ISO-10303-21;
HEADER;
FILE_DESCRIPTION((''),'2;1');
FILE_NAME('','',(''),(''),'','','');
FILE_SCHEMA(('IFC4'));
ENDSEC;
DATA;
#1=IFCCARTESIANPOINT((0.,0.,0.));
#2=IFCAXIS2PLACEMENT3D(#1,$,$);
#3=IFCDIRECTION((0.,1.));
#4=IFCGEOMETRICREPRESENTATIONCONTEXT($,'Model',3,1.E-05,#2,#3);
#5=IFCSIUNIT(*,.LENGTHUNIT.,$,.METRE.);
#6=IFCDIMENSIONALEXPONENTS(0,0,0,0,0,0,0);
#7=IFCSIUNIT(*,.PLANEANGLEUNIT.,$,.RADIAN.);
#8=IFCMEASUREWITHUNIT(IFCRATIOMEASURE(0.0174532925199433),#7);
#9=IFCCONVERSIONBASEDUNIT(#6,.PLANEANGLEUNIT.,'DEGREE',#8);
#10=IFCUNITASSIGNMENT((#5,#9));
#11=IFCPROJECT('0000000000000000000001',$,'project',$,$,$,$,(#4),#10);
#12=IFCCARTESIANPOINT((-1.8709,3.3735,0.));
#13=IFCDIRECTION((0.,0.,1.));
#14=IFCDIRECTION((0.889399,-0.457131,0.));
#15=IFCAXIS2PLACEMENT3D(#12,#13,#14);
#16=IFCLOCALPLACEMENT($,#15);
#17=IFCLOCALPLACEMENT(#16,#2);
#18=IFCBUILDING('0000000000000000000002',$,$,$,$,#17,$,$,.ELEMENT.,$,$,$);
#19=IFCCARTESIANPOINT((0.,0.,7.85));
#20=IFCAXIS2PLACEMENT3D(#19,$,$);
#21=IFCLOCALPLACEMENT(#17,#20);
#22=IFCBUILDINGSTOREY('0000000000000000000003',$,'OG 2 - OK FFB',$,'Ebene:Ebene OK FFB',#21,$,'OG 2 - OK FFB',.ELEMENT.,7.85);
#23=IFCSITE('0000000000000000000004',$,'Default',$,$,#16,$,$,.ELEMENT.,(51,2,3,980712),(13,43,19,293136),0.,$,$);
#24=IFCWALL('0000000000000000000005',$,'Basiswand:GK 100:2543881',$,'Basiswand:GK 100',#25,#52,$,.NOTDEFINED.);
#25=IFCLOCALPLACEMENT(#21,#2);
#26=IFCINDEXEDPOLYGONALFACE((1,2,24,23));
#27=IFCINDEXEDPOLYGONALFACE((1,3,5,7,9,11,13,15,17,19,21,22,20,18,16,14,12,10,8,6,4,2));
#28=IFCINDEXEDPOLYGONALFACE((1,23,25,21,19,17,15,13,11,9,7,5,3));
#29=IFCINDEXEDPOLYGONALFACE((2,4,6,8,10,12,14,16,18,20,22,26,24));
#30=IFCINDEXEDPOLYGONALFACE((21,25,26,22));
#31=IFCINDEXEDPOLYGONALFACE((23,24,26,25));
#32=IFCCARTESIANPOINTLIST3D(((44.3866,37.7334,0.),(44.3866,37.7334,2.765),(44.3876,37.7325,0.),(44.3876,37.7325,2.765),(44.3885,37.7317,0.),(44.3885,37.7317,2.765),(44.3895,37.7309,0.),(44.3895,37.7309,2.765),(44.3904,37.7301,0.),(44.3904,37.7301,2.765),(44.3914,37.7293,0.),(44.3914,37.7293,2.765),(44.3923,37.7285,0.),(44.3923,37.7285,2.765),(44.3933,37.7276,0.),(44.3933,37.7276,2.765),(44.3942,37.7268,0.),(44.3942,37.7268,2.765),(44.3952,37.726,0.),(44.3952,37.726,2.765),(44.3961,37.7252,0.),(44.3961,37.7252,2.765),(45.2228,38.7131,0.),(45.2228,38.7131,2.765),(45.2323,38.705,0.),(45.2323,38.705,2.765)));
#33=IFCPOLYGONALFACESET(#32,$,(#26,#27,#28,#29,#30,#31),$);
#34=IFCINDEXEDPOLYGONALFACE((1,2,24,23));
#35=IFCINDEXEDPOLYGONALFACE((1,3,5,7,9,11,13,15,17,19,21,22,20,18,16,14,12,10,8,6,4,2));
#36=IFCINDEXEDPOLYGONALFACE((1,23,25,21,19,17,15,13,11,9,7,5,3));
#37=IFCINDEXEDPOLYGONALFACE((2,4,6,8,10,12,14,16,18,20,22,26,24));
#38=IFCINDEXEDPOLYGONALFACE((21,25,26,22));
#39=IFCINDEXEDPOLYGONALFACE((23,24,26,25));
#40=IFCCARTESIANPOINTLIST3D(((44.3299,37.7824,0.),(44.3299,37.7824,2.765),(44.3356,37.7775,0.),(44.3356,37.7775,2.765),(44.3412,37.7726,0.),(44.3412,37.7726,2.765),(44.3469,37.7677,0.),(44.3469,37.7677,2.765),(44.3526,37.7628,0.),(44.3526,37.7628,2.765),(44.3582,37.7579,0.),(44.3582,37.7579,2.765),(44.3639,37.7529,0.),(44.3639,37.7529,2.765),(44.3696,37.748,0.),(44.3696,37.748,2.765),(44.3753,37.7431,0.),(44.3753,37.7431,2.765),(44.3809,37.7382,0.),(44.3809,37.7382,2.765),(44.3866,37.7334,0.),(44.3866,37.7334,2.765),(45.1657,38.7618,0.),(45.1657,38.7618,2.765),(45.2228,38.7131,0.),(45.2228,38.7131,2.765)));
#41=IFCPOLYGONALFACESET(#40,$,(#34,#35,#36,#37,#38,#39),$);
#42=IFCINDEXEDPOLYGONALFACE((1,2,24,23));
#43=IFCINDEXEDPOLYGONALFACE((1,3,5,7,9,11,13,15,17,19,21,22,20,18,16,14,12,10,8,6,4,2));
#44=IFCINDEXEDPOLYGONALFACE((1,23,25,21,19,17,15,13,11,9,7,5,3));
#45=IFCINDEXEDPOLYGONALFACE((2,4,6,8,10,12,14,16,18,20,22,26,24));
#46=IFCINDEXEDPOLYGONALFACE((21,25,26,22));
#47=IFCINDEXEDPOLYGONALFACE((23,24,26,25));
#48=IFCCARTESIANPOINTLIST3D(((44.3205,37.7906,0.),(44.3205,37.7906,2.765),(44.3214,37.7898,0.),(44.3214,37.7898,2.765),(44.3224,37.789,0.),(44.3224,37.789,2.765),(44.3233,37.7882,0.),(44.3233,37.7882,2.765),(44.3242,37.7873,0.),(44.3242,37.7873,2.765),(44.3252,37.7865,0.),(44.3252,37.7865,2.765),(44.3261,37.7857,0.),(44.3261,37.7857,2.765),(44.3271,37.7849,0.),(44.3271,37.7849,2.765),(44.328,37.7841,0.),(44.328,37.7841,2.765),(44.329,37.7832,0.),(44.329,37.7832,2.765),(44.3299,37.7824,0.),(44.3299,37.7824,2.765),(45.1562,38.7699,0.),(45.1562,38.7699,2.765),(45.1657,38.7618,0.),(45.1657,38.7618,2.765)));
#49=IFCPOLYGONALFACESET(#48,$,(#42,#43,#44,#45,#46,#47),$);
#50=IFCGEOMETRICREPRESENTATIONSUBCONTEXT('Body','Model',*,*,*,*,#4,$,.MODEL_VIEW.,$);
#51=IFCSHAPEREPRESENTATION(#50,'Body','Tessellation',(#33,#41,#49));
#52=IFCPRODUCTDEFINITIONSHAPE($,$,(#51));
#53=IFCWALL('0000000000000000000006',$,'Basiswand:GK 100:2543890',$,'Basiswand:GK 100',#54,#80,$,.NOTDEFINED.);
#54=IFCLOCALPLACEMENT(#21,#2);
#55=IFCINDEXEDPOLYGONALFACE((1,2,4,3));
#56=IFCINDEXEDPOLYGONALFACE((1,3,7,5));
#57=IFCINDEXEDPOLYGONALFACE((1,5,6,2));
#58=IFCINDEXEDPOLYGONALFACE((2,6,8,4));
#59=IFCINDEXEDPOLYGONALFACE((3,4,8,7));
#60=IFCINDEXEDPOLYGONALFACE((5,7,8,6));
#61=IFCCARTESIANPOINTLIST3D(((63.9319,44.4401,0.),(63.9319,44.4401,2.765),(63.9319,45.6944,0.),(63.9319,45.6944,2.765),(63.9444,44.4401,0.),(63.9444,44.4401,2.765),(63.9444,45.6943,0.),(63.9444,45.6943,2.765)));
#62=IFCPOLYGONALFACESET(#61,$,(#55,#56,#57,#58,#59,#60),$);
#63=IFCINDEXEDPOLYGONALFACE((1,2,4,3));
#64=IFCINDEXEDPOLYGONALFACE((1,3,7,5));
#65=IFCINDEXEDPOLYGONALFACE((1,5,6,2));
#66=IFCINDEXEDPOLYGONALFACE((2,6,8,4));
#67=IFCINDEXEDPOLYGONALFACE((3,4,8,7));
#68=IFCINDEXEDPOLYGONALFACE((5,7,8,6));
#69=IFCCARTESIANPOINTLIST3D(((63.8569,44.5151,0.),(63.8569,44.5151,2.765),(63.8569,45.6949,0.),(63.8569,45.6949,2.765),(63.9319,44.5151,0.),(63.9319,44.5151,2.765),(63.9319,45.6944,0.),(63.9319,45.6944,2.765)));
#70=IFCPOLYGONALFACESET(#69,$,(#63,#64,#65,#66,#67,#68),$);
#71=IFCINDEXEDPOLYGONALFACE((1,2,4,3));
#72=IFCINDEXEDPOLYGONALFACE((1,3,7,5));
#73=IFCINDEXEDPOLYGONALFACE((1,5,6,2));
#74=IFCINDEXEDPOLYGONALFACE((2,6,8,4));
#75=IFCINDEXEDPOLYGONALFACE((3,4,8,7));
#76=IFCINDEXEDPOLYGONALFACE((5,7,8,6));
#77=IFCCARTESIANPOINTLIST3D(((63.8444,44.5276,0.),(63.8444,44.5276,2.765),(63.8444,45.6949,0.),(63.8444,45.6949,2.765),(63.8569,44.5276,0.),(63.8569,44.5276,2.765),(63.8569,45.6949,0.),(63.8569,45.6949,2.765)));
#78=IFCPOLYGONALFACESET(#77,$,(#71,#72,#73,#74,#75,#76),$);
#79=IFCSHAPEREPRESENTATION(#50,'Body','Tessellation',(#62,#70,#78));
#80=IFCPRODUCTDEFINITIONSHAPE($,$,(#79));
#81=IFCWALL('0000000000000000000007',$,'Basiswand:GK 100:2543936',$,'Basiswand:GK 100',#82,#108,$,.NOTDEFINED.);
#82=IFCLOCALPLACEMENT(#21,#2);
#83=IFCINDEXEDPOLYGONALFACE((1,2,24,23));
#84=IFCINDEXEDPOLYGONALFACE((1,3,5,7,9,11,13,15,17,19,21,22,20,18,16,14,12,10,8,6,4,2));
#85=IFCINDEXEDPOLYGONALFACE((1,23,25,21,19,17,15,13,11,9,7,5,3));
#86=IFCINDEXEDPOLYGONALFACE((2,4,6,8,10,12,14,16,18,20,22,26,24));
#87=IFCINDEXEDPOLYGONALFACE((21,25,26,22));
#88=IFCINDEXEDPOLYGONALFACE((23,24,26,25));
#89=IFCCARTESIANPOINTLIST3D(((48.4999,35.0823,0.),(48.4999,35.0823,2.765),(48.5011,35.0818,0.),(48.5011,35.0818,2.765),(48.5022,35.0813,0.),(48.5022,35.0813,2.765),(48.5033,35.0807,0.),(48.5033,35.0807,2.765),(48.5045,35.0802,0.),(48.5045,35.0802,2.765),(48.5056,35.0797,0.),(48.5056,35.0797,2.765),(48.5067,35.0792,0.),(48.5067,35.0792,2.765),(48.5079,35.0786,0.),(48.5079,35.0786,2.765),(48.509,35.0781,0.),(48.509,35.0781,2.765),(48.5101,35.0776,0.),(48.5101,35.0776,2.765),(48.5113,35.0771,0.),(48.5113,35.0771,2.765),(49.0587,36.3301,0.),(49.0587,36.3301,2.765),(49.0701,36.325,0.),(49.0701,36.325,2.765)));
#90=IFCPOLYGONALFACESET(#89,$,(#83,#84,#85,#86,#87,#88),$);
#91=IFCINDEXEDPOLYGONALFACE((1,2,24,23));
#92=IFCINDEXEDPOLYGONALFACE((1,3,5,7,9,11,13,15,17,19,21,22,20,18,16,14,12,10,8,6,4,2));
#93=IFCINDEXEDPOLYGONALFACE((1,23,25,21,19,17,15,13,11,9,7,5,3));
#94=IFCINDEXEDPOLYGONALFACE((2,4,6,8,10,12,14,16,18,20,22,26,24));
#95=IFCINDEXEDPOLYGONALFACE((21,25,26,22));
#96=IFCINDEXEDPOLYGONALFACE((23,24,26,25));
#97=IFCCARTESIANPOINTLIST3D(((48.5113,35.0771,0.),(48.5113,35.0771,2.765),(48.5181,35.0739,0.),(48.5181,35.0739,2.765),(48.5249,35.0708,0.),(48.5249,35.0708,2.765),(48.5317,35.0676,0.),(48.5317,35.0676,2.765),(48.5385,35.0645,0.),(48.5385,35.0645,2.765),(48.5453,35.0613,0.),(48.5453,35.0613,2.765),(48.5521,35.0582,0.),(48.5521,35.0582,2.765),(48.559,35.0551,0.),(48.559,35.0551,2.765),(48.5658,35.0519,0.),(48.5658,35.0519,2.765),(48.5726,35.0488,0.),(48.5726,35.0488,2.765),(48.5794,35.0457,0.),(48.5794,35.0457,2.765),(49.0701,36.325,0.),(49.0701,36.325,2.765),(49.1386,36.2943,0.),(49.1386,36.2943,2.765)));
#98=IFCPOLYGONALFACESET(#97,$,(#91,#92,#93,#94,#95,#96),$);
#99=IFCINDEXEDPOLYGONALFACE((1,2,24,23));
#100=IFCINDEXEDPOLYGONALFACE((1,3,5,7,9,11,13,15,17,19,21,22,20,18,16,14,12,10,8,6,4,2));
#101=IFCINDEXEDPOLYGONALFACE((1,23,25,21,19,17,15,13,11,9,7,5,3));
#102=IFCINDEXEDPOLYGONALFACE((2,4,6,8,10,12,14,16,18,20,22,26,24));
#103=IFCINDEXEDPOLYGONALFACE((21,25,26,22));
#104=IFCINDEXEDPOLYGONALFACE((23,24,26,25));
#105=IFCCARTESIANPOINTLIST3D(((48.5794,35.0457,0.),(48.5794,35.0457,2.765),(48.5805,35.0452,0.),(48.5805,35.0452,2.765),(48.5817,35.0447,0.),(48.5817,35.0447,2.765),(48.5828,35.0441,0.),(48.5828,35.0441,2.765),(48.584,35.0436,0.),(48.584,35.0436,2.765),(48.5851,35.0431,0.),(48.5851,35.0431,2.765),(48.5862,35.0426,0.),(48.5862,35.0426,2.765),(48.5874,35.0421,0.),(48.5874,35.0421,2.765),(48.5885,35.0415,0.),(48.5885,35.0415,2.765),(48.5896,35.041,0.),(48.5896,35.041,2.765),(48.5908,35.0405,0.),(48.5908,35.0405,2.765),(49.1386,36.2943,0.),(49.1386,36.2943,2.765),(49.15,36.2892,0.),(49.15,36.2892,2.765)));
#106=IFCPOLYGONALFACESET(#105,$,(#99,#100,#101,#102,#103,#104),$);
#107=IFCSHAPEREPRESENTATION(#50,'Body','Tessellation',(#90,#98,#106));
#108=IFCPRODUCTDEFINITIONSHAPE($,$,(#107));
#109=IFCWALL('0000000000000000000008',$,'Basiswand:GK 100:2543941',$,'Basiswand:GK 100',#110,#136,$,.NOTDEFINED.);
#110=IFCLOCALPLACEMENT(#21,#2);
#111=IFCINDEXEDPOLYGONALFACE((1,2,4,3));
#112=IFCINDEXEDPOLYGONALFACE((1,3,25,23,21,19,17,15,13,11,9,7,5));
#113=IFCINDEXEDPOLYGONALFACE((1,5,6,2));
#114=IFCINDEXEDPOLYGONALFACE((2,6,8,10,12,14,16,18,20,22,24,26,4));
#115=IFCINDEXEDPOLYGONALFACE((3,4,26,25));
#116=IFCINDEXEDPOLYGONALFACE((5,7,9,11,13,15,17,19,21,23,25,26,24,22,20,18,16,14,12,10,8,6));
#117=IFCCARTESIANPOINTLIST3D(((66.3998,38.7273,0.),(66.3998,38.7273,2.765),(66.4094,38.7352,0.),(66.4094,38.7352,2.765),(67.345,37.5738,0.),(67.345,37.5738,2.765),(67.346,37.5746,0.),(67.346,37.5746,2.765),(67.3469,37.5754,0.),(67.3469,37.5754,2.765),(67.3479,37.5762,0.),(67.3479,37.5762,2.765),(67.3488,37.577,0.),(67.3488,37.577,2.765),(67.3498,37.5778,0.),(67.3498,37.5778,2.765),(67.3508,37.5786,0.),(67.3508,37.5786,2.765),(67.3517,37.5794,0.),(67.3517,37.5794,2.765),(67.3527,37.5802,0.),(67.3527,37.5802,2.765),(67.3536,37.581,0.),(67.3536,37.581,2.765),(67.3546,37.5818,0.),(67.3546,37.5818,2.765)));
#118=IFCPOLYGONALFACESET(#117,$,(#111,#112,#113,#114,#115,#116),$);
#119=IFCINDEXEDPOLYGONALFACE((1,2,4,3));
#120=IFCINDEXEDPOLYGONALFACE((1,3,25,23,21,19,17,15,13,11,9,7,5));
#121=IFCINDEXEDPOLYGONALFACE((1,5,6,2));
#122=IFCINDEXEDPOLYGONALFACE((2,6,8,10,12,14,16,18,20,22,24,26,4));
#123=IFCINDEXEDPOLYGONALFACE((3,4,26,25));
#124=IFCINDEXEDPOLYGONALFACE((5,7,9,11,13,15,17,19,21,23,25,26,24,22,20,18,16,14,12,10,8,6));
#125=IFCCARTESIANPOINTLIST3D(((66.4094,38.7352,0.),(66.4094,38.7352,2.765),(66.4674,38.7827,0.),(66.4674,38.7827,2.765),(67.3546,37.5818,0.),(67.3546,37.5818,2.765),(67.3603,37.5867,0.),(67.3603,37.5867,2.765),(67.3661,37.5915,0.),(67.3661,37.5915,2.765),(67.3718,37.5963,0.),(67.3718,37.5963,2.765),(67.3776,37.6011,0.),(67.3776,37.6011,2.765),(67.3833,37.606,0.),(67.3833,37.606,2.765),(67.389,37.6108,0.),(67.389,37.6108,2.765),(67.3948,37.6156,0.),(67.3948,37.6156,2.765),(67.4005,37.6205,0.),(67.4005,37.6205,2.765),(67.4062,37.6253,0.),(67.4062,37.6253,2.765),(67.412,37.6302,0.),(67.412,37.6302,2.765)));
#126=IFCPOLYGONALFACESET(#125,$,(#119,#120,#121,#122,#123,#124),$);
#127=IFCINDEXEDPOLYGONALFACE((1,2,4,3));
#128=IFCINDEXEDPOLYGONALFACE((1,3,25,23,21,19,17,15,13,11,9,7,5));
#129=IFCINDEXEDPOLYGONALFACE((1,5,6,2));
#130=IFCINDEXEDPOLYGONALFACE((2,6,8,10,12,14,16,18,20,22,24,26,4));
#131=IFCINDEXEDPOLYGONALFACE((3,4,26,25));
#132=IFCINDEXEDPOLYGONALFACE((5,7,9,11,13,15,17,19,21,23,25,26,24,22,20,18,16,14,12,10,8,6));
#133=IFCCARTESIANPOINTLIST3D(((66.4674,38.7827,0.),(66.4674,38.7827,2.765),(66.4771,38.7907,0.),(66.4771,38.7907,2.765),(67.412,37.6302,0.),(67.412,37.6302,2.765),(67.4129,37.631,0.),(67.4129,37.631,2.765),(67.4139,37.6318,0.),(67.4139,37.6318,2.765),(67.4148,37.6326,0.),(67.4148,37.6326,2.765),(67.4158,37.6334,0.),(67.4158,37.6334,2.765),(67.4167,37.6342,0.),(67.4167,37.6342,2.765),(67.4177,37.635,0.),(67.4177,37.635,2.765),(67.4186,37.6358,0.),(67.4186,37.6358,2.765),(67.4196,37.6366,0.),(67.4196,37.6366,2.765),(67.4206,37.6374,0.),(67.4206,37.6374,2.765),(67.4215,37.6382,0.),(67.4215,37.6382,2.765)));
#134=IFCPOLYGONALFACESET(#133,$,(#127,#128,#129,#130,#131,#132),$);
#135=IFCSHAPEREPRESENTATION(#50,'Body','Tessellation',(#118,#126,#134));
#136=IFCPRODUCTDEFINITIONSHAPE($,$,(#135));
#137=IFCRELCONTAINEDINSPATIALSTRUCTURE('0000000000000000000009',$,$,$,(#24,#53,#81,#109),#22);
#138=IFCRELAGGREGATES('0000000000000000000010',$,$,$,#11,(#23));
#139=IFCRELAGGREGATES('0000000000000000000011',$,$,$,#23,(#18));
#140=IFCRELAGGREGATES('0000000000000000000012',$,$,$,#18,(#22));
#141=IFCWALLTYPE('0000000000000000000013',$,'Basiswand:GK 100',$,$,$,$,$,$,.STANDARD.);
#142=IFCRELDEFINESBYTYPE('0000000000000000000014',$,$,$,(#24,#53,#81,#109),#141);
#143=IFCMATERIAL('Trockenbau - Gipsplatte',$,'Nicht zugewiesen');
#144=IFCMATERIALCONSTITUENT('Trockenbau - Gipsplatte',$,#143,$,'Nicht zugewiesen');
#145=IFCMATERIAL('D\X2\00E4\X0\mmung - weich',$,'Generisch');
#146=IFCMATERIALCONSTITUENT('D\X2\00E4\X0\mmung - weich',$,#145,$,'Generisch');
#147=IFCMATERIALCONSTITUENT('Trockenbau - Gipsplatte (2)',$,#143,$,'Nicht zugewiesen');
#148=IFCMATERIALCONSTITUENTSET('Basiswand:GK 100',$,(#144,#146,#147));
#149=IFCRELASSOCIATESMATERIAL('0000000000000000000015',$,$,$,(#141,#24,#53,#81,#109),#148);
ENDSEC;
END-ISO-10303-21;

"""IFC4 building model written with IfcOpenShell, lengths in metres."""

from ifc_helpers import new_model, entity, si_unit, converted_unit, direction, frame, origin, place, context, subcontext, project, spatial, indexed_curve, outline, extrude, material, constituent, constituent_set, type_object, element, save


model = new_model("IFC4")

# Units and contexts
model_context = context("Model", 3, precision=1e-05, world=origin(), true_north=direction((0.0, 1.0)))
body_context = subcontext(model_context, "Body", "Model", "MODEL_VIEW")
ifc_project = project(units=[si_unit("LENGTHUNIT", "METRE"), converted_unit("PLANEANGLEUNIT", "DEGREE", entity("IfcRatioMeasure", 0.0174532925199433), si_unit("PLANEANGLEUNIT", "RADIAN"), dimensions=[0, 0, 0, 0, 0, 0, 0])], contexts=[model_context])

# Site, building, storey
site_placement = place(None, frame((-1.8709, 3.3735, 0.0), z_axis=(0.0, 0.0, 1.0), x_axis=(0.889399, -0.457131, 0.0)))
site = spatial("IfcSite", under=ifc_project, at=site_placement, Name="Default", CompositionType="ELEMENT", RefLatitude=(51, 2, 3, 980712), RefLongitude=(13, 43, 19, 293136), RefElevation=0.0)
building_placement = place(site_placement, origin())
building = spatial("IfcBuilding", under=site, at=building_placement, CompositionType="ELEMENT")
storey_placement = place(building_placement, frame((0.0, 0.0, 7.85)))
storey = spatial("IfcBuildingStorey", under=building, at=storey_placement, Name="OG 2 - OK FFB", ObjectType="Ebene:Ebene OK FFB", LongName="OG 2 - OK FFB", CompositionType="ELEMENT", Elevation=7.85)

# Shared definitions
ifc_material_1 = material(Name="Trockenbau - Gipsplatte", Category="Nicht zugewiesen")
ifc_constituent_1 = constituent(ifc_material_1, Name="Trockenbau - Gipsplatte", Category="Nicht zugewiesen")
ifc_material_2 = material(Name="Dämmung - weich", Category="Generisch")
ifc_constituent_2 = constituent(ifc_material_2, Name="Dämmung - weich", Category="Generisch")
ifc_constituent_3 = constituent(ifc_material_1, Name="Trockenbau - Gipsplatte (2)", Category="Nicht zugewiesen")
ifc_constituent_set_1 = constituent_set(constituents=[ifc_constituent_1, ifc_constituent_2, ifc_constituent_3], Name="Basiswand:GK 100")
wall_type_1 = type_object("IfcWallType", Name="Basiswand:GK 100", PredefinedType="STANDARD", material=ifc_constituent_set_1)

# Walls
wall_1_placement = place(storey_placement, frame((44.3581, 37.7577, 0.0), z_axis=(0.0, 0.0, 1.0), x_axis=(0.649165, 0.760648, 0.0)))
element("IfcWall", 1, at=wall_1_placement, inside=storey, type_object=wall_type_1, material=ifc_constituent_set_1, Name="Basiswand:GK 100:2543881", ObjectType="Basiswand:GK 100", PredefinedType="NOTDEFINED", context=body_context, shape_type="SweptSolid", body=[
    extrude(outline(indexed_curve([(-0.0062, -0.644), (0.0063, -0.644), (0.0062, 0.644), (0.005, 0.644), (0.0038, 0.644), (0.0025, 0.644), (0.0013, 0.644), (0.0, 0.644), (-0.0012, 0.6441), (-0.0025, 0.6441), (-0.0037, 0.6441), (-0.005, 0.6441), (-0.0062, 0.6441), (-0.0062, -0.644)], self_intersect=False)), frame((0.6441, -0.0437, 0.0), z_axis=(0.0, 0.0, 1.0), x_axis=(0.0, 1.0, 0.0)), (0.0, 0.0, 1.0), 2.765),
    extrude(outline(indexed_curve([(-0.6442, -0.0375), (0.6439, -0.0375), (0.6439, 0.0375), (-0.6437, 0.0375), (-0.6437, 0.03), (-0.6438, 0.0225), (-0.6438, 0.015), (-0.6439, 0.0075), (-0.6439, 0.0), (-0.644, -0.0075), (-0.644, -0.015), (-0.6441, -0.0225), (-0.6441, -0.03), (-0.6442, -0.0375)], self_intersect=False)), frame((0.6442, 0.0, 0.0)), (0.0, 0.0, 1.0), 2.765),
    extrude(outline(indexed_curve([(-0.0005, -0.6437), (0.0008, -0.6437), (0.002, -0.6437), (0.0033, -0.6437), (0.0045, -0.6437), (0.0058, -0.6437), (0.007, -0.6437), (0.0083, -0.6437), (0.0095, -0.6437), (0.0108, -0.6437), (0.012, -0.6437), (0.0005, 0.6438), (-0.012, 0.6437), (-0.0005, -0.6437)], self_intersect=False)), frame((0.6444, 0.0438, 0.0), z_axis=(0.0, 0.0, 1.0), x_axis=(-0.008994, -0.99996, 0.0)), (0.0, 0.0, 1.0), 2.765),
])
wall_2_placement = place(storey_placement, frame((63.8944, 44.5276, 0.0), z_axis=(0.0, 0.0, 1.0), x_axis=(0.0, 1.0, 0.0)))
element("IfcWall", 2, at=wall_2_placement, inside=storey, type_object=wall_type_1, material=ifc_constituent_set_1, Name="Basiswand:GK 100:2543890", ObjectType="Basiswand:GK 100", PredefinedType="NOTDEFINED", context=body_context, shape_type="SweptSolid", body=[
    extrude(outline(indexed_curve([(-0.0025, -0.6271), (0.01, -0.6271), (0.0025, 0.6271), (-0.01, 0.6271), (-0.0025, -0.6271)], self_intersect=False)), frame((0.5396, -0.0438, 0.0), z_axis=(0.0, 0.0, 1.0), x_axis=(0.006008, 0.999982, 0.0)), (0.0, 0.0, 1.0), 2.765),
    extrude(outline(indexed_curve([(-0.5898, -0.0375), (0.5895, -0.0375), (0.59, 0.0375), (-0.5898, 0.0375), (-0.5898, -0.0375)], self_intersect=False)), frame((0.5773, 0.0, 0.0)), (0.0, 0.0, 1.0), 2.765),
    extrude(outline(indexed_curve([(-0.0063, -0.5836), (0.0062, -0.5836), (0.0062, 0.5836), (-0.0063, 0.5837), (-0.0063, -0.5836)], self_intersect=False)), frame((0.5836, 0.0437, 0.0), z_axis=(0.0, 0.0, 1.0), x_axis=(0.0, -1.0, 0.0)), (0.0, 0.0, 1.0), 2.765),
])
wall_3_placement = place(storey_placement, frame((49.1043, 36.3096, 0.0), z_axis=(0.0, 0.0, 1.0), x_axis=(-0.408713, -0.912663, 0.0)))
element("IfcWall", 3, at=wall_3_placement, inside=storey, type_object=wall_type_1, material=ifc_constituent_set_1, Name="Basiswand:GK 100:2543936", ObjectType="Basiswand:GK 100", PredefinedType="NOTDEFINED", context=body_context, shape_type="SweptSolid", body=[
    extrude(outline(indexed_curve([(0.0024, -0.6836), (0.0037, -0.6836), (0.0049, -0.6836), (0.0062, -0.6836), (0.0074, -0.6836), (0.0087, -0.6836), (0.0099, -0.6836), (0.0112, -0.6836), (0.0124, -0.6836), (0.0137, -0.6836), (0.0149, -0.6836), (-0.0024, 0.6836), (-0.0149, 0.6835), (0.0024, -0.6836)], self_intersect=False)), frame((0.6836, -0.0438, 0.0), z_axis=(0.0, 0.0, 1.0), x_axis=(0.01271, 0.999919, 0.0)), (0.0, 0.0, 1.0), 2.765),
    extrude(outline(indexed_curve([(-0.6839, -0.0375), (0.6835, -0.0375), (0.6836, -0.03), (0.6836, -0.0225), (0.6837, -0.015), (0.6838, -0.0075), (0.6839, 0.0), (0.684, 0.0075), (0.684, 0.015), (0.6841, 0.0225), (0.6842, 0.03), (0.6842, 0.0375), (-0.6839, 0.0375), (-0.6839, -0.0375)], self_intersect=False)), frame((0.6839, 0.0, 0.0)), (0.0, 0.0, 1.0), 2.765),
    extrude(outline(indexed_curve([(-0.0063, -0.6841), (0.0062, -0.6841), (0.0062, 0.684), (0.005, 0.684), (0.0038, 0.684), (0.0025, 0.684), (0.0013, 0.6841), (0.0, 0.6841), (-0.0012, 0.6841), (-0.0025, 0.6841), (-0.0037, 0.6841), (-0.005, 0.6841), (-0.0062, 0.6841), (-0.0063, -0.6841)], self_intersect=False)), frame((0.6841, 0.0437, 0.0), z_axis=(0.0, 0.0, 1.0), x_axis=(0.0, -1.0, 0.0)), (0.0, 0.0, 1.0), 2.765),
])

# Wall
wall_4_placement = place(storey_placement, frame((66.4384, 38.759, 0.0), z_axis=(0.0, 0.0, 1.0), x_axis=(0.633839, -0.773465, 0.0)))
element("IfcWall", 4, at=wall_4_placement, inside=storey, type_object=wall_type_1, material=ifc_constituent_set_1, Name="Basiswand:GK 100:2543941", ObjectType="Basiswand:GK 100", PredefinedType="NOTDEFINED", context=body_context, shape_type="SweptSolid", body=[
    extrude(outline(indexed_curve([(-0.0143, -0.7456), (-0.0131, -0.7456), (-0.0118, -0.7456), (-0.0106, -0.7456), (-0.0093, -0.7456), (-0.0081, -0.7456), (-0.0068, -0.7456), (-0.0056, -0.7456), (-0.0043, -0.7456), (-0.0031, -0.7456), (-0.0018, -0.7456), (0.0143, 0.7455), (0.0018, 0.7456), (-0.0143, -0.7456)], self_intersect=False)), frame((0.7456, -0.0438, 0.0), z_axis=(0.0, 0.0, 1.0), x_axis=(-0.010846, 0.999941, 0.0)), (0.0, 0.0, 1.0), 2.765),
    extrude(outline(indexed_curve([(-0.7453, -0.0375), (0.7458, -0.0375), (0.7457, -0.03), (0.7456, -0.0225), (0.7456, -0.015), (0.7455, -0.0075), (0.7454, 0.0), (0.7453, 0.0075), (0.7452, 0.015), (0.7451, 0.0225), (0.7449, 0.03), (0.7448, 0.0375), (-0.7453, 0.0375), (-0.7453, -0.0375)], self_intersect=False)), frame((0.7453, 0.0, 0.0)), (0.0, 0.0, 1.0), 2.765),
    extrude(outline(indexed_curve([(-0.0063, -0.745), (0.0062, -0.745), (0.0063, 0.7451), (0.005, 0.7451), (0.0037, 0.7451), (0.0025, 0.7451), (0.0012, 0.745), (0.0, 0.745), (-0.0013, 0.745), (-0.0025, 0.745), (-0.0038, 0.745), (-0.005, 0.7449), (-0.0062, 0.7449), (-0.0063, -0.745)], self_intersect=False)), frame((0.745, 0.0437, 0.0), z_axis=(0.0, 0.0, 1.0), x_axis=(0.0, -1.0, 0.0)), (0.0, 0.0, 1.0), 2.765),
])

save(model, "model.ifc")
